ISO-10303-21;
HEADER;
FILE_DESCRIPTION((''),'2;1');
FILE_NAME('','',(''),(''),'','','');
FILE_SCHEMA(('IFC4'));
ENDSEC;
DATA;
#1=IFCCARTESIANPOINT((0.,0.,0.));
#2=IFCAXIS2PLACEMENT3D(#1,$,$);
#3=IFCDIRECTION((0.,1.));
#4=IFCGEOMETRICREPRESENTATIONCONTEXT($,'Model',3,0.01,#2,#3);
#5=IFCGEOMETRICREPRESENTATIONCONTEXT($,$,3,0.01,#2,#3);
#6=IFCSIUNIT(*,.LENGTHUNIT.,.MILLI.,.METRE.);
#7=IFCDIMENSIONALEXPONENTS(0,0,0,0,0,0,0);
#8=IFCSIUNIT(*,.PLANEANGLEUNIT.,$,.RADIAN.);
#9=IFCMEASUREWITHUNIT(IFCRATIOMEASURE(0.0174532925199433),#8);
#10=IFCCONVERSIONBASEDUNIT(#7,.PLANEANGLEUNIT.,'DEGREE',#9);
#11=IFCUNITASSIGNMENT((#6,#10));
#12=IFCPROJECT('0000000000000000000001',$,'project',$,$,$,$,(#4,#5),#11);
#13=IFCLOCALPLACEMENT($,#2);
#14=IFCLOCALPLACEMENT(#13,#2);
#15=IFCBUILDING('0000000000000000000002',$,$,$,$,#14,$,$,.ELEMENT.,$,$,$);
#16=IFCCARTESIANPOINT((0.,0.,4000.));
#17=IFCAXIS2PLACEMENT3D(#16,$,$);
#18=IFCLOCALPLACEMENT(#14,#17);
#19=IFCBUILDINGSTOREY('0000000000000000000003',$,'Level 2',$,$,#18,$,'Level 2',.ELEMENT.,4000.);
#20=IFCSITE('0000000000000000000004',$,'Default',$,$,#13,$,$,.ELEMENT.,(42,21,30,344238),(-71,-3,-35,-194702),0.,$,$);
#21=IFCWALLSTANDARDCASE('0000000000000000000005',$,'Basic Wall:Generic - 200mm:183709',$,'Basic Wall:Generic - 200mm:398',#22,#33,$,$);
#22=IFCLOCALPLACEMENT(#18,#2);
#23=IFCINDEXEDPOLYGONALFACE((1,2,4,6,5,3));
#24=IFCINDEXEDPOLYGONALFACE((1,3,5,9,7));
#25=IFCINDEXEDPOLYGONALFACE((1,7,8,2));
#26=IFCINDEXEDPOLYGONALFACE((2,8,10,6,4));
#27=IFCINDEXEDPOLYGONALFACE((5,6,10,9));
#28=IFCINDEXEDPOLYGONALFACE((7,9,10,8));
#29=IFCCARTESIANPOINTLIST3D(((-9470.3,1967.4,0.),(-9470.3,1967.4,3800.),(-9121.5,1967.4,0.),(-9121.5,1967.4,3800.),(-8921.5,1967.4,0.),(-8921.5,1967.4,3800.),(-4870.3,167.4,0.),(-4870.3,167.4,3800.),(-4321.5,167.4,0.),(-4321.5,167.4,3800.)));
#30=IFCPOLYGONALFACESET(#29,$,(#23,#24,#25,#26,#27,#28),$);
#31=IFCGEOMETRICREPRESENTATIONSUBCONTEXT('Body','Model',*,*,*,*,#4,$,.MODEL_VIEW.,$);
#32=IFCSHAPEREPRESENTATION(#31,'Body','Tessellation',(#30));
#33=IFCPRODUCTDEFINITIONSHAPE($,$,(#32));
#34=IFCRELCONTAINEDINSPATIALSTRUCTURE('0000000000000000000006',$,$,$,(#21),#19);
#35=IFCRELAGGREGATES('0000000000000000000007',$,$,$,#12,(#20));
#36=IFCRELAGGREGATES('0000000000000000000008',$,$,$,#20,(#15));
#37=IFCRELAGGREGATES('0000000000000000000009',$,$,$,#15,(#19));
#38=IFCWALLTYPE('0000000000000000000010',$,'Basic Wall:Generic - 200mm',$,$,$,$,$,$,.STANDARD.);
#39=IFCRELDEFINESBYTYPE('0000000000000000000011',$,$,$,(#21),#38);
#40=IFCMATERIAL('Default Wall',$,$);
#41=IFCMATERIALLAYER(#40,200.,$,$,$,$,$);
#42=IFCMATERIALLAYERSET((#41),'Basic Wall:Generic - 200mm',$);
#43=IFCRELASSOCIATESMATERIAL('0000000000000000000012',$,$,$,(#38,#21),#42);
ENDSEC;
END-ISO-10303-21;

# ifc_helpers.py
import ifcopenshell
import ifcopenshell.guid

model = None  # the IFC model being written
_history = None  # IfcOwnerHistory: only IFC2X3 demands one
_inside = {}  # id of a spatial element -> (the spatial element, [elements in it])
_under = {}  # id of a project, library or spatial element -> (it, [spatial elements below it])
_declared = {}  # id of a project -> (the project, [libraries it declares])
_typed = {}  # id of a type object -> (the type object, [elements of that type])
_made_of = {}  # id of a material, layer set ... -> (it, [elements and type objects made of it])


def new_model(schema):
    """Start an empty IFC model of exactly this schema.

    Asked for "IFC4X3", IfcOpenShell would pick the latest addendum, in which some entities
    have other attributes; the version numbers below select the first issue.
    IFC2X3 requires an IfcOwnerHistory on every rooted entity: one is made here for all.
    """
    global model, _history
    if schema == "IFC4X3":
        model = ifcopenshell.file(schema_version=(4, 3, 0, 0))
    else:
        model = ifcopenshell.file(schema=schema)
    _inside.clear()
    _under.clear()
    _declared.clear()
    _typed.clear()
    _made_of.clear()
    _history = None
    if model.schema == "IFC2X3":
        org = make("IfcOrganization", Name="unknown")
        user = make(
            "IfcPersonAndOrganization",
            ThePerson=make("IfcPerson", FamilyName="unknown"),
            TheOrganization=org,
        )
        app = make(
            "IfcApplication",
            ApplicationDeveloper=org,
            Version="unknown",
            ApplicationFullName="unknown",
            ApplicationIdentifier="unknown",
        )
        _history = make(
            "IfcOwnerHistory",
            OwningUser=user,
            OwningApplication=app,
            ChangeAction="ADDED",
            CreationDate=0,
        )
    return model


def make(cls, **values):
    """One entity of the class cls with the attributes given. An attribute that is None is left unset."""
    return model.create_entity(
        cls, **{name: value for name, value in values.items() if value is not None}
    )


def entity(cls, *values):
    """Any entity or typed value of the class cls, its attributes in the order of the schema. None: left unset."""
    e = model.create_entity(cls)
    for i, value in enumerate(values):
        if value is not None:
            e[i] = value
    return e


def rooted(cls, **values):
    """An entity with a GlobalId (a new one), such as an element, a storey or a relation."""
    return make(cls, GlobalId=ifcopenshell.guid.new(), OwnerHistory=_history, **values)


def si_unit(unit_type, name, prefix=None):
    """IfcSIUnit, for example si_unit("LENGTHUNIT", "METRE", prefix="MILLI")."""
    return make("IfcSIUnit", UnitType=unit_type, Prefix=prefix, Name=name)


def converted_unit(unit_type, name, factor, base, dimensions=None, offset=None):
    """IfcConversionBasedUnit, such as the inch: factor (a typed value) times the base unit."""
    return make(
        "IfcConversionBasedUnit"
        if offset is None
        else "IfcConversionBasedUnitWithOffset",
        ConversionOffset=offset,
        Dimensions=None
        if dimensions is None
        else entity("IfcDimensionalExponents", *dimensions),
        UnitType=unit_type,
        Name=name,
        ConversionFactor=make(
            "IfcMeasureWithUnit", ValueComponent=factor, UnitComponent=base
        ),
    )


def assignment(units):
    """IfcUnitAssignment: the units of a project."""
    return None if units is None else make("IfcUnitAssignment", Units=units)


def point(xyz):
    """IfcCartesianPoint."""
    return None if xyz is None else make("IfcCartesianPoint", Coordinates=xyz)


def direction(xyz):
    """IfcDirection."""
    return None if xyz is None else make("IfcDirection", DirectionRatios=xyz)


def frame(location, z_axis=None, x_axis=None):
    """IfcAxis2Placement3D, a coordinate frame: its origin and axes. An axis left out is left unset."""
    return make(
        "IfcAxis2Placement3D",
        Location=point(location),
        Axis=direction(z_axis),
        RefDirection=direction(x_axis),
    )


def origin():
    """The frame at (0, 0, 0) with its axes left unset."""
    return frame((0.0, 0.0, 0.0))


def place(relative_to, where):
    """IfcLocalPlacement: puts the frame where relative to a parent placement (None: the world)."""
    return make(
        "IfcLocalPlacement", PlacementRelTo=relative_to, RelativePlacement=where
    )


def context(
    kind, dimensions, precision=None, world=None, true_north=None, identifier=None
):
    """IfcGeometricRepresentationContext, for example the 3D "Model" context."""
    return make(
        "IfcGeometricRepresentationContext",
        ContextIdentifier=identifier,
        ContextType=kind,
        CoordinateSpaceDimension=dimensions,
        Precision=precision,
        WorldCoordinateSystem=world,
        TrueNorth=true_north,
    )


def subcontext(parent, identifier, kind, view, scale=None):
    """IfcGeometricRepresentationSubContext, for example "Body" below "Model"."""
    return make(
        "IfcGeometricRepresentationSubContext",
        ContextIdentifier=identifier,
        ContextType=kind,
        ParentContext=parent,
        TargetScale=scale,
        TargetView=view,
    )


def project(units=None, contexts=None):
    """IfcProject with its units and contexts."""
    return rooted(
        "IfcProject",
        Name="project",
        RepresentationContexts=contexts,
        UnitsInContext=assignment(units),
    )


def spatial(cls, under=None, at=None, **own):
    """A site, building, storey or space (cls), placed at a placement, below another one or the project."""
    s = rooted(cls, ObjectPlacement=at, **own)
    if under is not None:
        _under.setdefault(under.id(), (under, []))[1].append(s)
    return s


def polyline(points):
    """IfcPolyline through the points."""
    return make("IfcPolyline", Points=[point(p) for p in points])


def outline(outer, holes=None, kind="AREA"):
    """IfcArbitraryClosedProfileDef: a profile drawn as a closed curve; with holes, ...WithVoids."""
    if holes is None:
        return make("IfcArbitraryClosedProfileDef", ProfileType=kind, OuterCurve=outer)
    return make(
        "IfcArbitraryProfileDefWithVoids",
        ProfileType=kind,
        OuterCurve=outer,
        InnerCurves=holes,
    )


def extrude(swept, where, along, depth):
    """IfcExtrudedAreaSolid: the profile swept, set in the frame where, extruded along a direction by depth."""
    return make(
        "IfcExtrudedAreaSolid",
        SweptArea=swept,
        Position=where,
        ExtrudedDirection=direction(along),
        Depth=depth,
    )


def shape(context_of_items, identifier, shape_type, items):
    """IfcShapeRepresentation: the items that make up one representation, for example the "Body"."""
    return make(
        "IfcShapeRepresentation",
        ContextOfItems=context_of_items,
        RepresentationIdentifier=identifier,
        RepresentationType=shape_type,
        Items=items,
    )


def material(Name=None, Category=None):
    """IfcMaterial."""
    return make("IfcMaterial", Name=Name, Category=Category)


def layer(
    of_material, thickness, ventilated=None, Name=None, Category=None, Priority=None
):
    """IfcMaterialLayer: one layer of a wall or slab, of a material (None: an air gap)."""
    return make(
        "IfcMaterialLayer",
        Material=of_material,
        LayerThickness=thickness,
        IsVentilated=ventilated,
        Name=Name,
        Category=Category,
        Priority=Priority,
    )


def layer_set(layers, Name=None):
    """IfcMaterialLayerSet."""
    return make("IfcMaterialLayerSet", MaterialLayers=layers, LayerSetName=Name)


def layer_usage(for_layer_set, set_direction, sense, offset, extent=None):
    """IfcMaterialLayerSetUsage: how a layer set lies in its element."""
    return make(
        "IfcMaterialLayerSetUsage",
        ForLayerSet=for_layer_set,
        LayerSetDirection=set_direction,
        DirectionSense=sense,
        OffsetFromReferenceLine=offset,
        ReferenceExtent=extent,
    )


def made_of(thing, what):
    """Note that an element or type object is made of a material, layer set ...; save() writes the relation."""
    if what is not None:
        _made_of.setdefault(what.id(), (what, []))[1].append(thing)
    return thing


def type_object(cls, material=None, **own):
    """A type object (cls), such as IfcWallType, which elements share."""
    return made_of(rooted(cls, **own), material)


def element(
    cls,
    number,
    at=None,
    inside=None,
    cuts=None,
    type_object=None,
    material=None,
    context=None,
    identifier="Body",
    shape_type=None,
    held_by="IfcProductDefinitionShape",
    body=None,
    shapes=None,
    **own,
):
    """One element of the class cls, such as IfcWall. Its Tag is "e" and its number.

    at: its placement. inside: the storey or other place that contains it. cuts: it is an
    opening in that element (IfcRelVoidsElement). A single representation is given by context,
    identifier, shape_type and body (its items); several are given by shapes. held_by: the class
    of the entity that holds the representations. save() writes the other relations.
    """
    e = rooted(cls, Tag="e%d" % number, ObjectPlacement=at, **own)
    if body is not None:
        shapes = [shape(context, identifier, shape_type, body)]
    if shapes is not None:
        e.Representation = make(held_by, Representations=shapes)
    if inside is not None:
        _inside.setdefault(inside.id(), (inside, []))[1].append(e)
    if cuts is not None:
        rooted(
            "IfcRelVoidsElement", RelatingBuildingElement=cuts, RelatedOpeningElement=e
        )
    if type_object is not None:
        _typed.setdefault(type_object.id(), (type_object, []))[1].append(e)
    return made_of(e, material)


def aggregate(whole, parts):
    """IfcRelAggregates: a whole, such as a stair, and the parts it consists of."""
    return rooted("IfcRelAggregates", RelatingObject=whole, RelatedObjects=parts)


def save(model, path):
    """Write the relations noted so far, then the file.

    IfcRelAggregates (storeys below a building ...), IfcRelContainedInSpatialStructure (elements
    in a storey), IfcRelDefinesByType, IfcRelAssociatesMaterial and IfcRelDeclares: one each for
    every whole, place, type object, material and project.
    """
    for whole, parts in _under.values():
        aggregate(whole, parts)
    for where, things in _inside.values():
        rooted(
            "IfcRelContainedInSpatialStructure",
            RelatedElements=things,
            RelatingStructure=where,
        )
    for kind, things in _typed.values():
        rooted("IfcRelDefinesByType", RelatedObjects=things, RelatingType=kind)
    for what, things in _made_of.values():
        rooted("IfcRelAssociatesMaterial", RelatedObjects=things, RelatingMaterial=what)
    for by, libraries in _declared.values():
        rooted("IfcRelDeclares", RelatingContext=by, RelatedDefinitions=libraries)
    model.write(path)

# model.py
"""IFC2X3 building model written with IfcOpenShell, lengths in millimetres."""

from ifc_helpers import new_model, entity, si_unit, converted_unit, direction, frame, origin, place, context, subcontext, project, spatial, polyline, outline, extrude, material, layer, layer_set, layer_usage, type_object, element, save


model = new_model("IFC2X3")

# Units and contexts
model_context = context("Model", 3, precision=0.01, world=origin(), true_north=direction((0.0, 1.0)))
context_of_model = context(None, 3, precision=0.01, world=origin(), true_north=direction((0.0, 1.0)))
body_context = subcontext(model_context, "Body", "Model", "MODEL_VIEW")
ifc_project = project(units=[si_unit("LENGTHUNIT", "METRE", prefix="MILLI"), converted_unit("PLANEANGLEUNIT", "DEGREE", entity("IfcRatioMeasure", 0.0174532925199433), si_unit("PLANEANGLEUNIT", "RADIAN"), dimensions=[0, 0, 0, 0, 0, 0, 0])], contexts=[model_context, context_of_model])

# Site, building, storey
site_placement = place(None, origin())
site = spatial("IfcSite", under=ifc_project, at=site_placement, Name="Default", CompositionType="ELEMENT", RefLatitude=(42, 21, 30, 344238), RefLongitude=(-71, -3, -35, -194702), RefElevation=0.0)
building_placement = place(site_placement, origin())
building = spatial("IfcBuilding", under=site, at=building_placement, CompositionType="ELEMENT")
storey_placement = place(building_placement, frame((0.0, 0.0, 4000.0)))
storey = spatial("IfcBuildingStorey", under=building, at=storey_placement, Name="Level 2", LongName="Level 2", CompositionType="ELEMENT", Elevation=4000.0)

# Wall
ifc_material_1 = material(Name="Default Wall")
ifc_layer_1 = layer(ifc_material_1, 200.0)
ifc_layer_set_1 = layer_set([ifc_layer_1], Name="Basic Wall:Generic - 200mm")
wall_type = type_object("IfcWallType", Name="Basic Wall:Generic - 200mm", PredefinedType="STANDARD", material=ifc_layer_set_1)
ifc_layer_usage_1 = layer_usage(ifc_layer_set_1, "AXIS2", "NEGATIVE", 100.0)
wall_1_placement = place(storey_placement, frame((-9433.9, 2060.5, 0.0), z_axis=(0.0, 0.0, 1.0), x_axis=(0.931243, -0.364399, 0.0)))
element("IfcWallStandardCase", 1, at=wall_1_placement, inside=storey, type_object=wall_type, material=ifc_layer_usage_1, Name="Basic Wall:Generic - 200mm:183709", ObjectType="Basic Wall:Generic - 200mm:398", context=body_context, shape_type="SweptSolid", body=[
    extrude(outline(polyline([(4939.6, -100.0), (5450.7, 100.0), (511.1, 100.0), (324.9, 27.1), (0.0, -100.0), (4939.6, -100.0)])), origin(), (0.0, 0.0, 1.0), 3800.0),
])

save(model, "model.ifc")
